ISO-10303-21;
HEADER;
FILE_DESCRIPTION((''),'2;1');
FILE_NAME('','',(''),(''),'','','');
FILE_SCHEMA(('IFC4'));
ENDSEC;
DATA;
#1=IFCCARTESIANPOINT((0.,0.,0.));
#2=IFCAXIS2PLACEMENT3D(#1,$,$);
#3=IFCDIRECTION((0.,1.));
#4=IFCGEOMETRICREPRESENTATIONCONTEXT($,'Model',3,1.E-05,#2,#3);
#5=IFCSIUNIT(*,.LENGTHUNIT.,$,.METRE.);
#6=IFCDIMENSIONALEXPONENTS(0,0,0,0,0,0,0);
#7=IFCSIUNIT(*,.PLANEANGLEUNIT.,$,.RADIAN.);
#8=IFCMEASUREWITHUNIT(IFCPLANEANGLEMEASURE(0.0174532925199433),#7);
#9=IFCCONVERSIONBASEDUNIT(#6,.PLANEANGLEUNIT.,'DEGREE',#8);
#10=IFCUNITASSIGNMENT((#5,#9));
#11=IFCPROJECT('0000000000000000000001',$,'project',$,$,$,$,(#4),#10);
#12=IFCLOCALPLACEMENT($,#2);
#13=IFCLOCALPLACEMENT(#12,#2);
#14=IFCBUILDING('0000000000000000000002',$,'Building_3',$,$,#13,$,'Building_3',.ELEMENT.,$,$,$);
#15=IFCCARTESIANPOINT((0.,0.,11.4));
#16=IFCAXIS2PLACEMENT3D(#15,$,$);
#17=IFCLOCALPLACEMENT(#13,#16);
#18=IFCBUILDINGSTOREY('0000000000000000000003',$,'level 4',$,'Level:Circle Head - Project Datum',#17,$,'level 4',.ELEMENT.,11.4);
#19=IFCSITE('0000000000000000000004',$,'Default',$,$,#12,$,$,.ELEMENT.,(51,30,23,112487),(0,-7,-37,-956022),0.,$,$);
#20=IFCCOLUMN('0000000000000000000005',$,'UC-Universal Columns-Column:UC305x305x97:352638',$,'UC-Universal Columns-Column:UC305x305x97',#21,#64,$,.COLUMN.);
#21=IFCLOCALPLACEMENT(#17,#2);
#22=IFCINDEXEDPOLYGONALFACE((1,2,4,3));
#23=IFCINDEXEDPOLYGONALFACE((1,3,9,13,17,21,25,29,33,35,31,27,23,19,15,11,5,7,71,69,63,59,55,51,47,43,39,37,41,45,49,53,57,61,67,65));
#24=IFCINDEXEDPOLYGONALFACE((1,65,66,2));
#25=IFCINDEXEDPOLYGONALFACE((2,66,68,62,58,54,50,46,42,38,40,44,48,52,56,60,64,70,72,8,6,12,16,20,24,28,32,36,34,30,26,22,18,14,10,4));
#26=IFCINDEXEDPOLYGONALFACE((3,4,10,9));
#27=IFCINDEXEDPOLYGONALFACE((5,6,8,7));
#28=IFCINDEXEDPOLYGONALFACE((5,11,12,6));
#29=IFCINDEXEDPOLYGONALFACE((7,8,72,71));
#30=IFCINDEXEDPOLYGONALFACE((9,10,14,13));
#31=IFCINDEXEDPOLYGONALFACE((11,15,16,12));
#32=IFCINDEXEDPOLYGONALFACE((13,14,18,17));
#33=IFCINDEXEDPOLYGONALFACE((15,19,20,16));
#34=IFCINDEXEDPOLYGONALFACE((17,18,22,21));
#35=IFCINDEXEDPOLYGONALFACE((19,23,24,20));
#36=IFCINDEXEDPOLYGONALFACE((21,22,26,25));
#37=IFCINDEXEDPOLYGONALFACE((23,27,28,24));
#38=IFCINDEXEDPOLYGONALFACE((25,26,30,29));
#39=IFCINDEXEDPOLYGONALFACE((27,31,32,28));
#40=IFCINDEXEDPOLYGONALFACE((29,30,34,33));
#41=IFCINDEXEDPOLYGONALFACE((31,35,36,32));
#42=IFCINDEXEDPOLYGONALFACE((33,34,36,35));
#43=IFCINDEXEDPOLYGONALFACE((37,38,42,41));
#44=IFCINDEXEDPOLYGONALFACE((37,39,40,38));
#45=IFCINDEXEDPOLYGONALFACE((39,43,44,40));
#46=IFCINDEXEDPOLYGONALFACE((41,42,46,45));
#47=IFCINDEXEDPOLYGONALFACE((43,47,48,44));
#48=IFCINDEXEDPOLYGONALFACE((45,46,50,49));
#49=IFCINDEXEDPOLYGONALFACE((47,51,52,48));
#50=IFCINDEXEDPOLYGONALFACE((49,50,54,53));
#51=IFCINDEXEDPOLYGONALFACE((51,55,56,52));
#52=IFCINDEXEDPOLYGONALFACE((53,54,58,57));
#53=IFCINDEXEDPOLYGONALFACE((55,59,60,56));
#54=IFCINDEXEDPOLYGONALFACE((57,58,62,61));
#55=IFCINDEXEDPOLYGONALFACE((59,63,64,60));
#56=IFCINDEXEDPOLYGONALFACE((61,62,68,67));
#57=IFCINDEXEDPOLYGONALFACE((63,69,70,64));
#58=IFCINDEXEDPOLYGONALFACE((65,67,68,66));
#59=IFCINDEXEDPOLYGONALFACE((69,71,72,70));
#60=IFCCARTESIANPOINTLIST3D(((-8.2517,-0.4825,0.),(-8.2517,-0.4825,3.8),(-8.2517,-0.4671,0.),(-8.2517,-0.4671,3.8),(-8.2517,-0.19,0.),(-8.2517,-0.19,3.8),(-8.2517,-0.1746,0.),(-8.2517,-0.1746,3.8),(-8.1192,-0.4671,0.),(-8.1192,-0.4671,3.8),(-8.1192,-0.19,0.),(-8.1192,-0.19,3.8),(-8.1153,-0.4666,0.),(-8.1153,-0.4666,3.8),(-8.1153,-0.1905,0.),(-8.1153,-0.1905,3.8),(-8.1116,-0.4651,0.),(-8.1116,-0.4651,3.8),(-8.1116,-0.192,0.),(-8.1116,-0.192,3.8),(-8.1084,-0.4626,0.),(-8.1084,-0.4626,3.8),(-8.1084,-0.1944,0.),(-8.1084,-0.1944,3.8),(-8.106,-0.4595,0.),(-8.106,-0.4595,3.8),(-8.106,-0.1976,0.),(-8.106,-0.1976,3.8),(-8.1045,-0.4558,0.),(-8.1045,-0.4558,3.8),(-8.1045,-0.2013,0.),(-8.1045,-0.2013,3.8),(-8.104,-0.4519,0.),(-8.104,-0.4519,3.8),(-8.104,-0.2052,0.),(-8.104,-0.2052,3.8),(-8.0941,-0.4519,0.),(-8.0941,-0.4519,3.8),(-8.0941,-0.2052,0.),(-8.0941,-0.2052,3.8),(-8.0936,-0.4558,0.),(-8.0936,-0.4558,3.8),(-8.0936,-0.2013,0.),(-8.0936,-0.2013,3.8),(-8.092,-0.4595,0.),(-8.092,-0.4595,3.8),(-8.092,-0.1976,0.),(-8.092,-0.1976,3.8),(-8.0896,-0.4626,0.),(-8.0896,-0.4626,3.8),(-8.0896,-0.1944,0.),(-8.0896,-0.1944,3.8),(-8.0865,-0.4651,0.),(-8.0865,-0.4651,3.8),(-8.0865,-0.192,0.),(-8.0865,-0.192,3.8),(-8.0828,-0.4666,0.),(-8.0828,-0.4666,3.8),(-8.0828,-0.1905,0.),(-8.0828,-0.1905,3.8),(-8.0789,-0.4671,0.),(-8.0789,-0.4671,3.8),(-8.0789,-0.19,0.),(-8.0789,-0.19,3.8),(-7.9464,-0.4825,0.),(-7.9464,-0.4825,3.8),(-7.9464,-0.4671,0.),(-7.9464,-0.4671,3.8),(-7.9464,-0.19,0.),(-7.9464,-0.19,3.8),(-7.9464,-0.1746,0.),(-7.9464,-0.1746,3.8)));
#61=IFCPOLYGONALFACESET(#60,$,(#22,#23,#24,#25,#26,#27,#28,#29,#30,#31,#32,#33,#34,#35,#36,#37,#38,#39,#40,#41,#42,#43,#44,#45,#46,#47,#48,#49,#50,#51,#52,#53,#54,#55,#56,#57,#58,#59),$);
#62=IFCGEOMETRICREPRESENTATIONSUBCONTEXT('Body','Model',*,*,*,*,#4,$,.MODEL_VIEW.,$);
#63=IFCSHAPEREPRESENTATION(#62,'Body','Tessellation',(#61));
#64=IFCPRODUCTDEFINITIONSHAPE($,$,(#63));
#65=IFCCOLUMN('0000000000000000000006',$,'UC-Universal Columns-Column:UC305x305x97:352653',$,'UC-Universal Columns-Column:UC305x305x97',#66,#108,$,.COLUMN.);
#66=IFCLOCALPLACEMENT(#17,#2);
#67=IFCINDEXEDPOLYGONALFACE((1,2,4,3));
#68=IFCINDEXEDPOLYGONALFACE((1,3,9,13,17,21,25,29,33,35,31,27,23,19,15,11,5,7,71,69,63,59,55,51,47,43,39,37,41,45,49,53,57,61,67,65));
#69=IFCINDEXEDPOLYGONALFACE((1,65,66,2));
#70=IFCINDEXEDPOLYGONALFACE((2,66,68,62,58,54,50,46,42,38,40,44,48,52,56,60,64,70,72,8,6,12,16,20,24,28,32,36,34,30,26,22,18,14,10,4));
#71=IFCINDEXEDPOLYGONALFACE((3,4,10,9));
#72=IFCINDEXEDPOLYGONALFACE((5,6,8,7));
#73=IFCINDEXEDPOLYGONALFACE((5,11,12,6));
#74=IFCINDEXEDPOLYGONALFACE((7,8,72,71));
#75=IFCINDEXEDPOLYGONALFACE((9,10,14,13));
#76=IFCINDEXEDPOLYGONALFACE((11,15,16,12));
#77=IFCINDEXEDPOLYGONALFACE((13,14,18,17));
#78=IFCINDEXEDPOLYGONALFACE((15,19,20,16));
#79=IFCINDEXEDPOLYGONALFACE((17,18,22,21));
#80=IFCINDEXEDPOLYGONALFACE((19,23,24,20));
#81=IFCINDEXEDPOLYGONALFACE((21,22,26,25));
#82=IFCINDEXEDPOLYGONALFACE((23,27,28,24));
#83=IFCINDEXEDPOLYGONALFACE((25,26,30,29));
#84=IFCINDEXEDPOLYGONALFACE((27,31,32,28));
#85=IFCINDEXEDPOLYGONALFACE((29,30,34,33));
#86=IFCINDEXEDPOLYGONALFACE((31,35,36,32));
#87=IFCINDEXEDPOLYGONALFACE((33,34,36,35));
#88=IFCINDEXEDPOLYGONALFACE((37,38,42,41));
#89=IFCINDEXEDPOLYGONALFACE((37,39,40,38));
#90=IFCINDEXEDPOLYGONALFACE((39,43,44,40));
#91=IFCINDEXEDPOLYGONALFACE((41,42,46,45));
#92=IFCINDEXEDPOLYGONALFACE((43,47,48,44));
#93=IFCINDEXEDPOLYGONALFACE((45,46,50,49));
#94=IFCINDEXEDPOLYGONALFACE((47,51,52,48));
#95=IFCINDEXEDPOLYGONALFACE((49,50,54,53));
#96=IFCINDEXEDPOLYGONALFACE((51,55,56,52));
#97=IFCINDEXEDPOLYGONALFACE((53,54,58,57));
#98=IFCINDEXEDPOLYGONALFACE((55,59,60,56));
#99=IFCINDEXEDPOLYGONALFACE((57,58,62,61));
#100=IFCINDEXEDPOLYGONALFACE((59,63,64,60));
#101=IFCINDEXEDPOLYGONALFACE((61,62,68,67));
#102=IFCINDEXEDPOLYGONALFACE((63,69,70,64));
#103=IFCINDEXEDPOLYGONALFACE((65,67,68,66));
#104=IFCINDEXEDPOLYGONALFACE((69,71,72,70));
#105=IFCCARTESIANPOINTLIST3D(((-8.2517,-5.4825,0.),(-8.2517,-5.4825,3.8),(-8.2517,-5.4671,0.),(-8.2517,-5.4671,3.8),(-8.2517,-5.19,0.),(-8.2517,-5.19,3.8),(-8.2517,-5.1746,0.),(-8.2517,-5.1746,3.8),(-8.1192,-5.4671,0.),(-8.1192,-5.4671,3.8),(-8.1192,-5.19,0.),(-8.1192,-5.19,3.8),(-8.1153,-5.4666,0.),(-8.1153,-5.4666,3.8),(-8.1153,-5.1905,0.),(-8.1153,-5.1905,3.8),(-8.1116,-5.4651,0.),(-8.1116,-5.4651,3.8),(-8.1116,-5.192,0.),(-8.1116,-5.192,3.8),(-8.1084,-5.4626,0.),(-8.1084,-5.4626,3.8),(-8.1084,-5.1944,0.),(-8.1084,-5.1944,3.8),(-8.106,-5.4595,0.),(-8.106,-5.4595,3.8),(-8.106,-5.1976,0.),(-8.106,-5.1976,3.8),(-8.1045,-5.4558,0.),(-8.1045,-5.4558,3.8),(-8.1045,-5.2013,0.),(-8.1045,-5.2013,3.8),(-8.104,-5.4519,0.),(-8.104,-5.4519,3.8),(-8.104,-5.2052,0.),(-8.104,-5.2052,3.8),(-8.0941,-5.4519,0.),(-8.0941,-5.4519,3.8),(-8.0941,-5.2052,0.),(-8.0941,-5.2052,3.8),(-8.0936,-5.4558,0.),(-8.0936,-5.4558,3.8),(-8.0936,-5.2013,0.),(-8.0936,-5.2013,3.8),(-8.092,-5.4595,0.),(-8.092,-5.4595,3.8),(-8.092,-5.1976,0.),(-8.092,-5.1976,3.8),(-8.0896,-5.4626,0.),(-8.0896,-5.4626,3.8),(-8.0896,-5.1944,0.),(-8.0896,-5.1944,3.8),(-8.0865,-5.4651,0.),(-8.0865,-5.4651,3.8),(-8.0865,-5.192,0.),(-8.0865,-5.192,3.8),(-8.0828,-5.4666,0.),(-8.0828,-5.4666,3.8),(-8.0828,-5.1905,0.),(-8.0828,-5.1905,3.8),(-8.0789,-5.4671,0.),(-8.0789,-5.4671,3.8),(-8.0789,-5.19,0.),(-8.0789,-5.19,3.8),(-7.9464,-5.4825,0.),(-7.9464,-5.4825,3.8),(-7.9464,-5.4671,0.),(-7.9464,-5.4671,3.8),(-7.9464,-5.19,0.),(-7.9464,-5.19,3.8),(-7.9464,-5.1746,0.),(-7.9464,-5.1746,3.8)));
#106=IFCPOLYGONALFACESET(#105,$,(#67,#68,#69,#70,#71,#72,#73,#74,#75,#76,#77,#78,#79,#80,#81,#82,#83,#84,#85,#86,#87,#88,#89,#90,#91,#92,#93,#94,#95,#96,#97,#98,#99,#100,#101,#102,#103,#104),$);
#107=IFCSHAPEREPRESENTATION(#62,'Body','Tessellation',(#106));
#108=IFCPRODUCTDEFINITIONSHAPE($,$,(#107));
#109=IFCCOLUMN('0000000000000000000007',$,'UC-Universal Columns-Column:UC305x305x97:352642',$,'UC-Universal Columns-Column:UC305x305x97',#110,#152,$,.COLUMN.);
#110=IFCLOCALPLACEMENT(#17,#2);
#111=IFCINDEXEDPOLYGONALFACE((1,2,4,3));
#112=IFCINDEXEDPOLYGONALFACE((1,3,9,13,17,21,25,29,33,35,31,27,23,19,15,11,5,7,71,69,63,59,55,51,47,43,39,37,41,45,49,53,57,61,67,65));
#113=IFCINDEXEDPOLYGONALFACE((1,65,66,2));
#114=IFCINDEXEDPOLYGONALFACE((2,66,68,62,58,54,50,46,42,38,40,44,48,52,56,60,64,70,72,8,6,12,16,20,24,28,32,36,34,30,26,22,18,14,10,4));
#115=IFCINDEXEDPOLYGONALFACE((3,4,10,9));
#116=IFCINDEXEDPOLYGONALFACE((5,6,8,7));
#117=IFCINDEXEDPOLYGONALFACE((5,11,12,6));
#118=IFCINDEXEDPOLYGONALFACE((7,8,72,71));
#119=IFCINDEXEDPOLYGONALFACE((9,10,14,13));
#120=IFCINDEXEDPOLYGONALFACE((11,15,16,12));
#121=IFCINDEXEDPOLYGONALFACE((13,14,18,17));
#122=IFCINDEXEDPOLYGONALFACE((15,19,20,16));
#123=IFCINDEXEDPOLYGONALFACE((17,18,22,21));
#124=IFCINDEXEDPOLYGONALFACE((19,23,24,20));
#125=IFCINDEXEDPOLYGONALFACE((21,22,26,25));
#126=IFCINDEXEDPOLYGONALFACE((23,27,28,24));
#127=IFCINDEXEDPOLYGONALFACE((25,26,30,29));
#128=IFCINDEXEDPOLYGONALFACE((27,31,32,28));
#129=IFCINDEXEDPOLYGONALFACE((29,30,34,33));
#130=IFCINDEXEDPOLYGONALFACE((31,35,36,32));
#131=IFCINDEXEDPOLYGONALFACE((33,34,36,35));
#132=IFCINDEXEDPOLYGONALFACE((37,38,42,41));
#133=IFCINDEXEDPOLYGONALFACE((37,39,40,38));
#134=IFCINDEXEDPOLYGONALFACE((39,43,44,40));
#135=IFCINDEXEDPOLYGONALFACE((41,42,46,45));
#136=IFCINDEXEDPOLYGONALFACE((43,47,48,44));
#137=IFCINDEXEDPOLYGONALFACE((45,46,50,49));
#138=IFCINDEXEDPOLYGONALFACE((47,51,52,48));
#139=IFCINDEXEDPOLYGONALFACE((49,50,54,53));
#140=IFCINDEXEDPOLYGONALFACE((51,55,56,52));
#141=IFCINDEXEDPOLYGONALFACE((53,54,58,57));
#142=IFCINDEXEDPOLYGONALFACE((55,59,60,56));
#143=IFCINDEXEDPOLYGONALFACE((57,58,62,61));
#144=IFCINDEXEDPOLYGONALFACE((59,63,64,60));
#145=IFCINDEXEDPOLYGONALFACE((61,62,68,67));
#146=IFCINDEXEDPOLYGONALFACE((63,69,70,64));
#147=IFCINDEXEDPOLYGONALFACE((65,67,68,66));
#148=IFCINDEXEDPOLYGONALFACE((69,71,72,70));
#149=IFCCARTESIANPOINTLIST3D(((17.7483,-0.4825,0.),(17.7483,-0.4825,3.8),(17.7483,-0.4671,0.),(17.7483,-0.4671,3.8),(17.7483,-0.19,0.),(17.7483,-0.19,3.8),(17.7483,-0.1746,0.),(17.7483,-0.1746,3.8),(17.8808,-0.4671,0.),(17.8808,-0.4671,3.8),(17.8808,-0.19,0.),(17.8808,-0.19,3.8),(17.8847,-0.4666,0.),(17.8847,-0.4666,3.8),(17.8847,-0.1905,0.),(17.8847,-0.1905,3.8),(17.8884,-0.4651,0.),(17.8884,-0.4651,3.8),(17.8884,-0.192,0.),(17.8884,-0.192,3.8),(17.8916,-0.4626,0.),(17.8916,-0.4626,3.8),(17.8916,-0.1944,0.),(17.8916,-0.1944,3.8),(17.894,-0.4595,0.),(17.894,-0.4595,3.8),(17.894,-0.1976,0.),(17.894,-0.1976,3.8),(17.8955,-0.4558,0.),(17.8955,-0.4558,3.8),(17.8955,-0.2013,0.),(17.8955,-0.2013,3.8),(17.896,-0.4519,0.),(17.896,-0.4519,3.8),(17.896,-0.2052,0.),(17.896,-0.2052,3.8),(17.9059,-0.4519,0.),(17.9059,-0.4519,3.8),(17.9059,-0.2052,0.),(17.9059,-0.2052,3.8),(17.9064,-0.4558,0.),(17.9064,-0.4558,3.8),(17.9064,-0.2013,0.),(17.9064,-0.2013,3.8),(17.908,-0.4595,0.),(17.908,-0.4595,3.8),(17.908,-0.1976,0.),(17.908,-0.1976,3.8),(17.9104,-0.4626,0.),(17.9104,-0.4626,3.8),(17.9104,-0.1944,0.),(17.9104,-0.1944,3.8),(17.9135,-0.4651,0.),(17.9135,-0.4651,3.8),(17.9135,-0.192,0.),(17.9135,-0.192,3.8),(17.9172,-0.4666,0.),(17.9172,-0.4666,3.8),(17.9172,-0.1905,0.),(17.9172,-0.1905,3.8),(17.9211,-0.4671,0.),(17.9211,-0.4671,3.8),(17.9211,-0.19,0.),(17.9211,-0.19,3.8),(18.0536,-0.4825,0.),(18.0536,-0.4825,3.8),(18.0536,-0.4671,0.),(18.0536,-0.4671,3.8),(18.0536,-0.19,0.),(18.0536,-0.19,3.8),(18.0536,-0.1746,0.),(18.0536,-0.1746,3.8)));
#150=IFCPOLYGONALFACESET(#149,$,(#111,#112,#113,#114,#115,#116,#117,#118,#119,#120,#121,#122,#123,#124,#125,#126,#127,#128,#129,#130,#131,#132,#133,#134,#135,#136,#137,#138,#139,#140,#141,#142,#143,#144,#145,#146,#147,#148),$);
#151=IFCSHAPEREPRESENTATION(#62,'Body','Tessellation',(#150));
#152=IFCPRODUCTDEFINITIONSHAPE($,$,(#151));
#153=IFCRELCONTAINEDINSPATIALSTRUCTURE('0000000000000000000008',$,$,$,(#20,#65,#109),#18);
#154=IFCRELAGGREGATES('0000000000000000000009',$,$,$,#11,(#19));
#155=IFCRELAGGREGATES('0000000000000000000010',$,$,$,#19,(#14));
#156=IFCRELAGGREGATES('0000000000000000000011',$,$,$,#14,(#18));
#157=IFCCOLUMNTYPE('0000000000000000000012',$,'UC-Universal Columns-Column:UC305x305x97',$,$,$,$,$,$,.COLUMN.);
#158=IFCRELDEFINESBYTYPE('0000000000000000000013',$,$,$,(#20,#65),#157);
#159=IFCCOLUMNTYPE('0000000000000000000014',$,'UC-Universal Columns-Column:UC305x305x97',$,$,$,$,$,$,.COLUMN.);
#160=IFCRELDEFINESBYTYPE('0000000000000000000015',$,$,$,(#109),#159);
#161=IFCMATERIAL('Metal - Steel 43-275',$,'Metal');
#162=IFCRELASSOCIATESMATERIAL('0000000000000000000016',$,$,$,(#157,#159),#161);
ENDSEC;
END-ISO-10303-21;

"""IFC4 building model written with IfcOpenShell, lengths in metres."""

from ifc_helpers import new_model, entity, si_unit, converted_unit, direction, frame, frame_2d, origin, origin_2d_with_axis, place, context, subcontext, project, spatial, i_section, extrude, source, transform, mapped, material, material_profile, profile_set, type_object, type_shapes, element, save


model = new_model("IFC4")

# Units and contexts
model_context = context("Model", 3, precision=1e-05, world=origin(), true_north=direction((0.0, 1.0)))
body_context = subcontext(model_context, "Body", "Model", "MODEL_VIEW")
ifc_project = project(units=[si_unit("LENGTHUNIT", "METRE"), converted_unit("PLANEANGLEUNIT", "DEGREE", entity("IfcPlaneAngleMeasure", 0.0174532925199433), si_unit("PLANEANGLEUNIT", "RADIAN"), dimensions=[0, 0, 0, 0, 0, 0, 0])], contexts=[model_context])

# Site, building, storey
site_placement = place(None, origin())
site = spatial("IfcSite", under=ifc_project, at=site_placement, Name="Default", CompositionType="ELEMENT", RefLatitude=(51, 30, 23, 112487), RefLongitude=(0, -7, -37, -956022), RefElevation=0.0)
building_placement = place(site_placement, origin())
building = spatial("IfcBuilding", under=site, at=building_placement, Name="Building_3", LongName="Building_3", CompositionType="ELEMENT")
storey_placement = place(building_placement, frame((0.0, 0.0, 11.4)))
storey = spatial("IfcBuildingStorey", under=building, at=storey_placement, Name="level 4", ObjectType="Level:Circle Head - Project Datum", LongName="level 4", CompositionType="ELEMENT", Elevation=11.4)

# Columns
ifc_material_1 = material(Name="Metal - Steel 43-275", Category="Metal")
ifc_material_profile_1 = material_profile(ifc_material_1, i_section(OverallWidth=0.3053, OverallDepth=0.3079, WebThickness=0.0099, FlangeThickness=0.0154, FilletRadius=0.0152, at=frame_2d((0.0, 0.0), x_axis=(1.0, 0.0))), Name="UC305x305x97")
ifc_profile_set_1 = profile_set([ifc_material_profile_1], Name="UC305x305x97")
column_type_1 = type_object("IfcColumnType", Name="UC-Universal Columns-Column:UC305x305x97", PredefinedType="COLUMN", material=ifc_profile_set_1)
shared_shape_1 = source(origin(), body_context, "Body", "SweptSolid", [
    extrude(i_section(OverallWidth=0.3053, OverallDepth=0.3079, WebThickness=0.0099, FlangeThickness=0.0154, FilletRadius=0.0152, at=origin_2d_with_axis()), frame((0.0, 0.0, 11.4), z_axis=(0.0, 0.0, 1.0), x_axis=(-1.0, 0.0, 0.0)), (0.0, 0.0, 1.0), 3.8),
])
type_shapes(column_type_1, [shared_shape_1])
for number, where, name in (
    (1, (-8.099, -0.3285, -11.4), "UC-Universal Columns-Column:UC305x305x97:352638"),
    (2, (-8.099, -5.3285, -11.4), "UC-Universal Columns-Column:UC305x305x97:352653"),
):
    element("IfcColumn", number, at=place(storey_placement, frame(where)), inside=storey, type_object=column_type_1, Name=name, ObjectType="UC-Universal Columns-Column:UC305x305x97", PredefinedType="COLUMN", context=body_context, shape_type="MappedRepresentation", body=[
        mapped(shared_shape_1, transform((0.0, 0.0, 0.0), scale=1.0)),
    ])
column_type_2 = type_object("IfcColumnType", Name="UC-Universal Columns-Column:UC305x305x97", PredefinedType="COLUMN", material=ifc_profile_set_1)
shared_shape_2 = source(origin(), body_context, "Body", "SweptSolid", [
    extrude(i_section(OverallWidth=0.3053, OverallDepth=0.3079, WebThickness=0.0099, FlangeThickness=0.0154, FilletRadius=0.0152, at=frame_2d((0.0, 0.0), x_axis=(1.0, 0.0))), frame((17.901, -0.3285, 11.4), z_axis=(0.0, 0.0, 1.0), x_axis=(-1.0, 0.0, 0.0)), (0.0, 0.0, 1.0), 3.8),
])
type_shapes(column_type_2, [shared_shape_2])
column_1_placement = place(storey_placement, frame((0.0, 0.0, -11.4)))
element("IfcColumn", 3, at=column_1_placement, inside=storey, type_object=column_type_2, Name="UC-Universal Columns-Column:UC305x305x97:352642", ObjectType="UC-Universal Columns-Column:UC305x305x97", PredefinedType="COLUMN", context=body_context, shape_type="MappedRepresentation", body=[
    mapped(shared_shape_2, transform((0.0, 0.0, 0.0), scale=1.0)),
])

save(model, "model.ifc")
